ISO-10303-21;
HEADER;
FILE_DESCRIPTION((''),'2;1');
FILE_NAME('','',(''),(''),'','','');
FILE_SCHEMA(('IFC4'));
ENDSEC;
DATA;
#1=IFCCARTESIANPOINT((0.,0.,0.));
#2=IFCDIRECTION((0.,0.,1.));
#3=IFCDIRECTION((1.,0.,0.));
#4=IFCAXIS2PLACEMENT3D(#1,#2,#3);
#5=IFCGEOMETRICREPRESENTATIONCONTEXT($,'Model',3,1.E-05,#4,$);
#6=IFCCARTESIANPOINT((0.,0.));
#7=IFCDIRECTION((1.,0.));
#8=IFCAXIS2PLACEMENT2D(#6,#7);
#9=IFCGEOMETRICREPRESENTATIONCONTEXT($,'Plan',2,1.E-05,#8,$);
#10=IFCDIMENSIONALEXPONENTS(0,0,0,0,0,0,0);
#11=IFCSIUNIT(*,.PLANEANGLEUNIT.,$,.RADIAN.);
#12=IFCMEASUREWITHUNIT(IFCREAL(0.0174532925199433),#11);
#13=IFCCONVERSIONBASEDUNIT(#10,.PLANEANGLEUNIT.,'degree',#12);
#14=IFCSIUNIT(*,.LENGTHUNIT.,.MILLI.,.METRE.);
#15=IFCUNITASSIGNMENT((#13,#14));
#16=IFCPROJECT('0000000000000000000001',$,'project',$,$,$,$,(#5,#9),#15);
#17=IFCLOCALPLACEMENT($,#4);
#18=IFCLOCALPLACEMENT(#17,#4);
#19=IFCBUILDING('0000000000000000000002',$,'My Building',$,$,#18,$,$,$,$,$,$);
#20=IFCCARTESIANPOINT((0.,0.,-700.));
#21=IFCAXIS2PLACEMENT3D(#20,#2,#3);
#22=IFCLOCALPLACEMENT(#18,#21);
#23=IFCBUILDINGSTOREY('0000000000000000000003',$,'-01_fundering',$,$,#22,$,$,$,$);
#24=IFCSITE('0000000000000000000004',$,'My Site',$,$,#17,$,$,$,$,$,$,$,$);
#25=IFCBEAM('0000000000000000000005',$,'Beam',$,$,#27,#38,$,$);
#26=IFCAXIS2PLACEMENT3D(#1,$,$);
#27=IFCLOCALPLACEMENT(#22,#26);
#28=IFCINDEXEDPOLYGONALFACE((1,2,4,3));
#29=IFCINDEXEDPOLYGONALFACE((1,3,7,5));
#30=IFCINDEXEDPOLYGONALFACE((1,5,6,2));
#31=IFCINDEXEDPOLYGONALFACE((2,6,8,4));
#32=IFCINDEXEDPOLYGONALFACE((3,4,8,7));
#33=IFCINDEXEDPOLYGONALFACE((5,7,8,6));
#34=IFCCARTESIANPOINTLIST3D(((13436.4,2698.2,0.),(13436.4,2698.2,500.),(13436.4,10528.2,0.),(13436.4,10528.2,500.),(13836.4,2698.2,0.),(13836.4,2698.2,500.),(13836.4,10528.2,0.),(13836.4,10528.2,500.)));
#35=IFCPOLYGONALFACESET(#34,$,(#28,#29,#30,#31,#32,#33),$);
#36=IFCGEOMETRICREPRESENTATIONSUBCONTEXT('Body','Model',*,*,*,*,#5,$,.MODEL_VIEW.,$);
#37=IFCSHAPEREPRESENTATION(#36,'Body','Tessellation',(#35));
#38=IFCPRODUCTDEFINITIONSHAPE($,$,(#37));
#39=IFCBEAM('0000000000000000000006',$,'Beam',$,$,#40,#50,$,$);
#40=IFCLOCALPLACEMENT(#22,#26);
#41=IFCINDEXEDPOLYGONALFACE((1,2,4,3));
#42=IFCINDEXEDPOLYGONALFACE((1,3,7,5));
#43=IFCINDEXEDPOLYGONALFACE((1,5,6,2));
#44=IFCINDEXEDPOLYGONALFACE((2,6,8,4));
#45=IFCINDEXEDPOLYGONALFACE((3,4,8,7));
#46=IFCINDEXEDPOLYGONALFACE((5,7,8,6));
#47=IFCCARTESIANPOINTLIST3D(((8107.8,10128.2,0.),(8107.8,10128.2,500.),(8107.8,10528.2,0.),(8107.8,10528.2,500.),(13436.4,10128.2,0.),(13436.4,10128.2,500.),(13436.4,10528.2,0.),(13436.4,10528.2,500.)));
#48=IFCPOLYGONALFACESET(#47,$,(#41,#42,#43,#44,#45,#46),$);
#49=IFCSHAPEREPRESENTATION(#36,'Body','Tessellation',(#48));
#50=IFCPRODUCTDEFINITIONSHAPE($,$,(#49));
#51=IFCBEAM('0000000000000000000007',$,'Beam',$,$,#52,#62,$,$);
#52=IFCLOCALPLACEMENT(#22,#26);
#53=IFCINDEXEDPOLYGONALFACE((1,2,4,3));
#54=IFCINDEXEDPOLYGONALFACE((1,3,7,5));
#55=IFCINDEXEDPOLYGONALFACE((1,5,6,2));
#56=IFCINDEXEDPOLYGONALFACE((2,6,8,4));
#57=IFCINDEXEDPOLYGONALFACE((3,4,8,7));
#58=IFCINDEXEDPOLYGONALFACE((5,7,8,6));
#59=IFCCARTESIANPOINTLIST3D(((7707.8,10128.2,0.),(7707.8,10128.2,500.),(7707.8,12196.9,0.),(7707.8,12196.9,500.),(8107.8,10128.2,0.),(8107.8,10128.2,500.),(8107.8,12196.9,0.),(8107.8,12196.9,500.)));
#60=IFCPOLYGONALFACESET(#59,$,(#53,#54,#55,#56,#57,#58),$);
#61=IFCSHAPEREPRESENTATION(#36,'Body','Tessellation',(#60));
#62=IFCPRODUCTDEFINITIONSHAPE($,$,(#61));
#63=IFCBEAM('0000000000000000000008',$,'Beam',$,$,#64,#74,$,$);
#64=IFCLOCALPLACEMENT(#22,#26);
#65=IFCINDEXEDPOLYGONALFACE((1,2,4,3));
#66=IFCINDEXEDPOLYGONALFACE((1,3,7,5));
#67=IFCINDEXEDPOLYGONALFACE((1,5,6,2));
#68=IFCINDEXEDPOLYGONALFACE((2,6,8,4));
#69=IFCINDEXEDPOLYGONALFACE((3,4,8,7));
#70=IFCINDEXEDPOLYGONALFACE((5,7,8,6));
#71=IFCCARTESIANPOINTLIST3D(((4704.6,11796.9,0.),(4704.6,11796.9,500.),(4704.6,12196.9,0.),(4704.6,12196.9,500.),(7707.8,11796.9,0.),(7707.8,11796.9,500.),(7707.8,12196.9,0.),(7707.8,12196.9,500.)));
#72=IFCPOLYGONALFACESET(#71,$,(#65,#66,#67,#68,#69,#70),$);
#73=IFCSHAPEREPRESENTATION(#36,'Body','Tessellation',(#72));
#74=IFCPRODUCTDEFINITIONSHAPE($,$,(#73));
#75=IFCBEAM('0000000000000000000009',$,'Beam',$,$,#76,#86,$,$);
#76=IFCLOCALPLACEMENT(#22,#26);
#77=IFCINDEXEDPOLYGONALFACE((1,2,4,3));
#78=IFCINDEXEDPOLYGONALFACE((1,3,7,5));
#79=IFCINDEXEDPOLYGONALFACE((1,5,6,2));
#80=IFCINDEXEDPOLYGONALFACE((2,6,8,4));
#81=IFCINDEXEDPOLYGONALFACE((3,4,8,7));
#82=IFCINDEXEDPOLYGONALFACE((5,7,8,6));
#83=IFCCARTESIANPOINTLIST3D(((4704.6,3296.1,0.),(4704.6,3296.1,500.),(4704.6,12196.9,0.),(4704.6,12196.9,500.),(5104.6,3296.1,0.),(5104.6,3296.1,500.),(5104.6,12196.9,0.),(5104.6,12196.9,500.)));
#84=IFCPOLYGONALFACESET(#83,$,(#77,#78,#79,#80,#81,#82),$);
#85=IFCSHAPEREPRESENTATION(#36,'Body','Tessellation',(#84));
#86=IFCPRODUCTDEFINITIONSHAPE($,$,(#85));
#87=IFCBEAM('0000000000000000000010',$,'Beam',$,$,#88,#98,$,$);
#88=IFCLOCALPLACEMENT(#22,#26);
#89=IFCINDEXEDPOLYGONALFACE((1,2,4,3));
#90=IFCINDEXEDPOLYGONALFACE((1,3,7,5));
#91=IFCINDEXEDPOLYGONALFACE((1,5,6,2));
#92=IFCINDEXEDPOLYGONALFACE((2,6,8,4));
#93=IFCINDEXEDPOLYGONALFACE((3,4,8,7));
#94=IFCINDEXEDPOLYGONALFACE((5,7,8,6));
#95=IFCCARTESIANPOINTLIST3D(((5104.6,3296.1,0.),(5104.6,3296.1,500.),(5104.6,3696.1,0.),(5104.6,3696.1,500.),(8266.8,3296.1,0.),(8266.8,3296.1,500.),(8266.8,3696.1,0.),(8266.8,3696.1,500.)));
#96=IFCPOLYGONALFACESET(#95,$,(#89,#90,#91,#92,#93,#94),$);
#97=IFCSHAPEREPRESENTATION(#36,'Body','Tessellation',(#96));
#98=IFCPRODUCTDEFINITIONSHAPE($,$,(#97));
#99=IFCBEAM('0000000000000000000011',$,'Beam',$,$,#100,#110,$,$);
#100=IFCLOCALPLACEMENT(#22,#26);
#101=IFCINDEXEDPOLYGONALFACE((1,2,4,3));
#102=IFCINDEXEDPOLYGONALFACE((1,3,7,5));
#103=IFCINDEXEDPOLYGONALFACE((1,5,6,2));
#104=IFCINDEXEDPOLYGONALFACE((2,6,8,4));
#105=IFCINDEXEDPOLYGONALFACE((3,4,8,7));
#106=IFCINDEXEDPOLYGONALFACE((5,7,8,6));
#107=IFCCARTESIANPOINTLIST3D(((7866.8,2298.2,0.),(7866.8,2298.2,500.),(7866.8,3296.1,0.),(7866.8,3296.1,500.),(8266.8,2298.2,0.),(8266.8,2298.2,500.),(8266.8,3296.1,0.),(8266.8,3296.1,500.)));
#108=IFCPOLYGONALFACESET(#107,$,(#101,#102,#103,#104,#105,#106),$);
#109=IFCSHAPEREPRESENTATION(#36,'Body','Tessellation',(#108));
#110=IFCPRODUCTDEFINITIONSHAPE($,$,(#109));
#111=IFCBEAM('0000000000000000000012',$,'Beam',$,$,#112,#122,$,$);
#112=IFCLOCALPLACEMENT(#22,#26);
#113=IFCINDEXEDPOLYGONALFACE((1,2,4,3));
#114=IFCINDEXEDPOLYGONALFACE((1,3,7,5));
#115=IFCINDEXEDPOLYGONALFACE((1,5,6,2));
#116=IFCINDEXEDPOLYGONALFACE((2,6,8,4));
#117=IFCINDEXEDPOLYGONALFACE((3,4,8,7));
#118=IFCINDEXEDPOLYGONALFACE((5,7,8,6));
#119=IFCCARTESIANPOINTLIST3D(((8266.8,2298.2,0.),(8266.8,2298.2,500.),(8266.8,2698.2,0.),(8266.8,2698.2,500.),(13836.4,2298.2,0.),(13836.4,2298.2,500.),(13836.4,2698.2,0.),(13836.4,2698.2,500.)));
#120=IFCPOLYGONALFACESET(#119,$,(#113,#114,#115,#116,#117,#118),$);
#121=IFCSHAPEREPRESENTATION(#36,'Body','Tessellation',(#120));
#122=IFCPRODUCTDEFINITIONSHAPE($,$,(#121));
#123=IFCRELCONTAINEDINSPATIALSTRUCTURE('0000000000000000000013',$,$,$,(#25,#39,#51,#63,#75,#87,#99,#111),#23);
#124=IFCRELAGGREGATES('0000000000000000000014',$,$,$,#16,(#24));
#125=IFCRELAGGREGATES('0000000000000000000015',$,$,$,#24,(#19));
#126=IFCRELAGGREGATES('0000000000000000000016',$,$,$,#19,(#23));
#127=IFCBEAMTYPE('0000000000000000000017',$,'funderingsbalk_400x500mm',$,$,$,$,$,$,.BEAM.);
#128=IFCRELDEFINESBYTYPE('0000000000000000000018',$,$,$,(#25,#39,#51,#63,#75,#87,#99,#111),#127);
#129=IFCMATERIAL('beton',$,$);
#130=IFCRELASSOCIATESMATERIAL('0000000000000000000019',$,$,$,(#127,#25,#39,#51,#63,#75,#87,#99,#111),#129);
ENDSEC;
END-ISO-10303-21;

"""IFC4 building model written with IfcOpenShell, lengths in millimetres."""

from ifc_helpers import new_model, entity, si_unit, converted_unit, frame, origin_with_axes, origin_2d_with_axis, place, context, subcontext, project, spatial, rectangle, extrude, material, material_profile, profile_set, profile_usage, type_object, element, save


model = new_model("IFC4")

# Units and contexts
model_context = context("Model", 3, precision=1e-05, world=origin_with_axes())
plan_context = context("Plan", 2, precision=1e-05, world=origin_2d_with_axis())
body_context = subcontext(model_context, "Body", "Model", "MODEL_VIEW")
ifc_project = project(units=[converted_unit("PLANEANGLEUNIT", "degree", entity("IfcReal", 0.0174532925199433), si_unit("PLANEANGLEUNIT", "RADIAN"), dimensions=[0, 0, 0, 0, 0, 0, 0]), si_unit("LENGTHUNIT", "METRE", prefix="MILLI")], contexts=[model_context, plan_context])

# Site, building, storey
site_placement = place(None, origin_with_axes())
site = spatial("IfcSite", under=ifc_project, at=site_placement, Name="My Site")
building_placement = place(site_placement, origin_with_axes())
building = spatial("IfcBuilding", under=site, at=building_placement, Name="My Building")
storey_placement = place(building_placement, frame((0.0, 0.0, -700.0), z_axis=(0.0, 0.0, 1.0), x_axis=(1.0, 0.0, 0.0)))
storey = spatial("IfcBuildingStorey", under=building, at=storey_placement, Name="-01_fundering")

# Beams
ifc_material = material(Name="beton")
ifc_material_profile = material_profile(ifc_material, rectangle(XDim=400.0, YDim=500.0))
ifc_profile_set = profile_set([ifc_material_profile])
ifc_profile_usage_1 = profile_usage(ifc_profile_set, cardinal=3)
beam_type = type_object("IfcBeamType", Name="funderingsbalk_400x500mm", PredefinedType="BEAM", material=ifc_profile_set)
beam_1_placement = place(storey_placement, frame((13836.4, 2698.2, 0.0), z_axis=(0.0, 1.0, 0.0), x_axis=(-1.0, 0.0, 0.0)))
element("IfcBeam", 1, at=beam_1_placement, inside=storey, type_object=beam_type, material=ifc_profile_usage_1, Name="Beam", context=body_context, shape_type="SweptSolid", body=[
    extrude(rectangle(XDim=400.0, YDim=500.0), frame((200.0, 250.0, 0.0), z_axis=(0.0, 0.0, 1.0), x_axis=(1.0, 0.0, 0.0)), (0.0, 0.0, 1.0), 7830.0),
])
ifc_profile_usage_2 = profile_usage(ifc_profile_set, cardinal=3)
beam_2_placement = place(storey_placement, frame((8107.8, 10128.2, 0.0), z_axis=(1.0, 0.0, 0.0), x_axis=(0.0, 1.0, 0.0)))
element("IfcBeam", 2, at=beam_2_placement, inside=storey, type_object=beam_type, material=ifc_profile_usage_2, Name="Beam", context=body_context, shape_type="SweptSolid", body=[
    extrude(rectangle(XDim=400.0, YDim=500.0), frame((200.0, 250.0, 0.0), z_axis=(0.0, 0.0, 1.0), x_axis=(1.0, 0.0, 0.0)), (0.0, 0.0, 1.0), 5328.7),
])
ifc_profile_usage_3 = profile_usage(ifc_profile_set, cardinal=3)
beam_3_placement = place(storey_placement, frame((8107.8, 10128.2, 0.0), z_axis=(0.0, 1.0, 0.0), x_axis=(-1.0, 0.0, 0.0)))
element("IfcBeam", 3, at=beam_3_placement, inside=storey, type_object=beam_type, material=ifc_profile_usage_3, Name="Beam", context=body_context, shape_type="SweptSolid", body=[
    extrude(rectangle(XDim=400.0, YDim=500.0), frame((200.0, 250.0, 0.0), z_axis=(0.0, 0.0, 1.0), x_axis=(1.0, 0.0, 0.0)), (0.0, 0.0, 1.0), 2068.8),
])
ifc_profile_usage_4 = profile_usage(ifc_profile_set, cardinal=3)
beam_4_placement = place(storey_placement, frame((7707.8, 12196.9, 0.0), z_axis=(-1.0, 0.0, 0.0), x_axis=(0.0, -1.0, 0.0)))
element("IfcBeam", 4, at=beam_4_placement, inside=storey, type_object=beam_type, material=ifc_profile_usage_4, Name="Beam", context=body_context, shape_type="SweptSolid", body=[
    extrude(rectangle(XDim=400.0, YDim=500.0), frame((200.0, 250.0, 0.0), z_axis=(0.0, 0.0, 1.0), x_axis=(1.0, 0.0, 0.0)), (0.0, 0.0, 1.0), 3003.2),
])
ifc_profile_usage_5 = profile_usage(ifc_profile_set, cardinal=3)
beam_5_placement = place(storey_placement, frame((4704.6, 12196.9, 0.0), z_axis=(0.0, -1.0, 0.0), x_axis=(1.0, 0.0, 0.0)))
element("IfcBeam", 5, at=beam_5_placement, inside=storey, type_object=beam_type, material=ifc_profile_usage_5, Name="Beam", context=body_context, shape_type="SweptSolid", body=[
    extrude(rectangle(XDim=400.0, YDim=500.0), frame((200.0, 250.0, 0.0), z_axis=(0.0, 0.0, 1.0), x_axis=(1.0, 0.0, 0.0)), (0.0, 0.0, 1.0), 8900.9),
])
ifc_profile_usage_6 = profile_usage(ifc_profile_set, cardinal=3)
beam_6_placement = place(storey_placement, frame((5104.6, 3296.1, 0.0), z_axis=(1.0, 0.0, 0.0), x_axis=(0.0, 1.0, 0.0)))
element("IfcBeam", 6, at=beam_6_placement, inside=storey, type_object=beam_type, material=ifc_profile_usage_6, Name="Beam", context=body_context, shape_type="SweptSolid", body=[
    extrude(rectangle(XDim=400.0, YDim=500.0), frame((200.0, 250.0, 0.0), z_axis=(0.0, 0.0, 1.0), x_axis=(1.0, 0.0, 0.0)), (0.0, 0.0, 1.0), 3162.2),
])
ifc_profile_usage_7 = profile_usage(ifc_profile_set, cardinal=3)
beam_7_placement = place(storey_placement, frame((7866.8, 3296.1, 0.0), z_axis=(0.0, -1.0, 0.0), x_axis=(1.0, 0.0, 0.0)))
element("IfcBeam", 7, at=beam_7_placement, inside=storey, type_object=beam_type, material=ifc_profile_usage_7, Name="Beam", context=body_context, shape_type="SweptSolid", body=[
    extrude(rectangle(XDim=400.0, YDim=500.0), frame((200.0, 250.0, 0.0), z_axis=(0.0, 0.0, 1.0), x_axis=(1.0, 0.0, 0.0)), (0.0, 0.0, 1.0), 997.9),
])
ifc_profile_usage_8 = profile_usage(ifc_profile_set, cardinal=3)
beam_8_placement = place(storey_placement, frame((8266.8, 2298.2, 0.0), z_axis=(1.0, 0.0, 0.0), x_axis=(0.0, 1.0, 0.0)))
element("IfcBeam", 8, at=beam_8_placement, inside=storey, type_object=beam_type, material=ifc_profile_usage_8, Name="Beam", context=body_context, shape_type="SweptSolid", body=[
    extrude(rectangle(XDim=400.0, YDim=500.0), frame((200.0, 250.0, 0.0), z_axis=(0.0, 0.0, 1.0), x_axis=(1.0, 0.0, 0.0)), (0.0, 0.0, 1.0), 5569.7),
])

save(model, "model.ifc")
